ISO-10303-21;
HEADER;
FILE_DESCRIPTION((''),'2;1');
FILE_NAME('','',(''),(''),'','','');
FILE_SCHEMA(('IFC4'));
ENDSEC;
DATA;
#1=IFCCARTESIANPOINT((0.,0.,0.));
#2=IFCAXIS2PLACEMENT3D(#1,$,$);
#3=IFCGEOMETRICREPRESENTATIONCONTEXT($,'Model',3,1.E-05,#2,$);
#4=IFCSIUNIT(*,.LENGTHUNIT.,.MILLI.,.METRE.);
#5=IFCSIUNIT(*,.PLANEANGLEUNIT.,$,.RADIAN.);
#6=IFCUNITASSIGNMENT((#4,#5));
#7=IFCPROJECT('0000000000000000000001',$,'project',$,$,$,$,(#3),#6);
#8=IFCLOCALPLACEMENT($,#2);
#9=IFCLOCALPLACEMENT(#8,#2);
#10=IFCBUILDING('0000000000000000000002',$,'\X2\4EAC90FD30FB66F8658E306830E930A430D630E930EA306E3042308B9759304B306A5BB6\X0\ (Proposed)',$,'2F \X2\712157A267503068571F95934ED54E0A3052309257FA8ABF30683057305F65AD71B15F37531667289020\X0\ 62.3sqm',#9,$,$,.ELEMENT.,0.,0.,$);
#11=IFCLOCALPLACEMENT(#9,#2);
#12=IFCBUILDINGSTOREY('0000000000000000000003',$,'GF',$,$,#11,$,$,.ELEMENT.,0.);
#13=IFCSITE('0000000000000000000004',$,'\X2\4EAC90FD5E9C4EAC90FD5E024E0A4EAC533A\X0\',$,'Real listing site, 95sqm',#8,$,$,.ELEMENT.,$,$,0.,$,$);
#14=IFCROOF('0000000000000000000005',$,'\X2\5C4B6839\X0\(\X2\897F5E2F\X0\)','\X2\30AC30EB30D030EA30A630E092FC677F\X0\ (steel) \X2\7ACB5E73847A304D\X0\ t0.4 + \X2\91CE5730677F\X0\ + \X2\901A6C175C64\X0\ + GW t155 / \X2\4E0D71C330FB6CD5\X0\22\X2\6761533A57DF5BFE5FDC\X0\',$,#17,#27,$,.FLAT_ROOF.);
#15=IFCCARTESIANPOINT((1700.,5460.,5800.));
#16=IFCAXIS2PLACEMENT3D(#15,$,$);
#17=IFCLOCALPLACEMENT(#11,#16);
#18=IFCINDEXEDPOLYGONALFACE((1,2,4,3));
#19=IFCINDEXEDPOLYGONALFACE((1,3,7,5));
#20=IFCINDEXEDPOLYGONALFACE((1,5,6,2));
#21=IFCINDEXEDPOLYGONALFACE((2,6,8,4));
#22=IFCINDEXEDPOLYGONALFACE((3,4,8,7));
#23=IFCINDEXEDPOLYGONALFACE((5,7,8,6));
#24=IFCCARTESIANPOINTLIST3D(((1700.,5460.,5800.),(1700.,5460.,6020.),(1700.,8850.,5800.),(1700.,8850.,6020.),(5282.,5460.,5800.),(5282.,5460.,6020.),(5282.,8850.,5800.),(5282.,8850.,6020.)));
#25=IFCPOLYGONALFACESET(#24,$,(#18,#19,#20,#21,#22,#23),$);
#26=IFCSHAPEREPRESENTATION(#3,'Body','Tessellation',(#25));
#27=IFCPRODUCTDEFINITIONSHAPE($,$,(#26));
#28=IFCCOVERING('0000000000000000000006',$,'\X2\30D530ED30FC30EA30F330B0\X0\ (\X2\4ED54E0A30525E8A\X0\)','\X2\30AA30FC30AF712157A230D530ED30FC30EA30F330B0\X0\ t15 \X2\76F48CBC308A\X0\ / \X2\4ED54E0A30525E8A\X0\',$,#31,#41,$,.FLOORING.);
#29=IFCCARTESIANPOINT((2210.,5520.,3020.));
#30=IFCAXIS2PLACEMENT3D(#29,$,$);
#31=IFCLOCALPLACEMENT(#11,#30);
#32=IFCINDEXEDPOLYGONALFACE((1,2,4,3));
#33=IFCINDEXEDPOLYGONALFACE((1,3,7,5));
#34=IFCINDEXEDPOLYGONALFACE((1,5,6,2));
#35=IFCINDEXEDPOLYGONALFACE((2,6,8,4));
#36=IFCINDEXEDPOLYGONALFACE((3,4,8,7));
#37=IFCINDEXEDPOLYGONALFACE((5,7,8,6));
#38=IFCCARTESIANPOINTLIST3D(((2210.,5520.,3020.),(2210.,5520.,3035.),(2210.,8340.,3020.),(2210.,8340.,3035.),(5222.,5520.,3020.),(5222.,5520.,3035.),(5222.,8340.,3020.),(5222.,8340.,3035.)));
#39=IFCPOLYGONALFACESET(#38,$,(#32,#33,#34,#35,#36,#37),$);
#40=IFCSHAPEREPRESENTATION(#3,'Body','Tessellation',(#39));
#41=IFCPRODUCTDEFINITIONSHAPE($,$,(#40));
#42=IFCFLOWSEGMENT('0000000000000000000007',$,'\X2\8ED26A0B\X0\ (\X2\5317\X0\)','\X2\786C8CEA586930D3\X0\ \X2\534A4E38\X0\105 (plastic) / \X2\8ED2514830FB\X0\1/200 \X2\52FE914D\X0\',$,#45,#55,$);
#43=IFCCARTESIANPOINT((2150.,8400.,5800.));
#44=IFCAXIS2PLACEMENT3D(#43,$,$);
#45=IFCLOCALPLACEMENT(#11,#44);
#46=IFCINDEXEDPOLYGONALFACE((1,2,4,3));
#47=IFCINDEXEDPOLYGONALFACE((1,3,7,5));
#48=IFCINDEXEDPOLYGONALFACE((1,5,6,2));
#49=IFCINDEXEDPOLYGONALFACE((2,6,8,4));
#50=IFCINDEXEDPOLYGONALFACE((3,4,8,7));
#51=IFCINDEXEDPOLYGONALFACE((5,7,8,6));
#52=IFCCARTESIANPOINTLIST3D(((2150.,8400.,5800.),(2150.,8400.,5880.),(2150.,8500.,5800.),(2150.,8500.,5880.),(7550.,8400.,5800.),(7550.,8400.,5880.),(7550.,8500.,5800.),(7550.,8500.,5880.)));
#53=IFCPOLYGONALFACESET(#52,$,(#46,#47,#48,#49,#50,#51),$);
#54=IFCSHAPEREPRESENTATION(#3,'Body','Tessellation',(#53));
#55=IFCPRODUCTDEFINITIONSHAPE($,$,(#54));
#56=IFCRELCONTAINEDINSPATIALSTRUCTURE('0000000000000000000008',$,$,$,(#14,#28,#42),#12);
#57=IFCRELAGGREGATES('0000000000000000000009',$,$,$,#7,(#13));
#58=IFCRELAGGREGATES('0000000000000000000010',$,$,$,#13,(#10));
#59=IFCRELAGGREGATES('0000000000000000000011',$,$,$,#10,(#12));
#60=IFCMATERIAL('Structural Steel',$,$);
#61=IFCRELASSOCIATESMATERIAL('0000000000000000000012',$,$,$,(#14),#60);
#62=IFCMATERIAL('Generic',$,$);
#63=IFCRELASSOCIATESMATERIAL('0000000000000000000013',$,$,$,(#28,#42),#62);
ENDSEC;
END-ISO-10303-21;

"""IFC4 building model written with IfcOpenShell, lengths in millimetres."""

from ifc_helpers import new_model, si_unit, frame, frame_2d, origin, place, context, project, spatial, rectangle, extrude, material, element, save


model = new_model("IFC4")

# Units and contexts
model_context = context("Model", 3, precision=1e-05, world=origin())
ifc_project = project(units=[si_unit("LENGTHUNIT", "METRE", prefix="MILLI"), si_unit("PLANEANGLEUNIT", "RADIAN")], contexts=[model_context])

# Site, building, storey
site_placement = place(None, origin())
site = spatial("IfcSite", under=ifc_project, at=site_placement, Name="京都府京都市上京区", ObjectType="Real listing site, 95sqm", CompositionType="ELEMENT", RefElevation=0.0)
building_placement = place(site_placement, origin())
building = spatial("IfcBuilding", under=site, at=building_placement, Name="京都・書斎とライブラリのある静かな家 (Proposed)", ObjectType="2F 無垢材と土間仕上げを基調とした断熱強化木造 62.3sqm", CompositionType="ELEMENT", ElevationOfRefHeight=0.0, ElevationOfTerrain=0.0)
storey_placement = place(building_placement, origin())
storey = spatial("IfcBuildingStorey", under=building, at=storey_placement, Name="GF", CompositionType="ELEMENT", Elevation=0.0)

# Roof
ifc_material_1 = material(Name="Structural Steel")
for number, where, name in (
    (1, (1700.0, 5460.0, 5800.0), "屋根(西帯)"),
):
    element("IfcRoof", number, at=place(storey_placement, frame(where)), inside=storey, material=ifc_material_1, Name=name, Description="ガルバリウム鋼板 (steel) 立平葺き t0.4 + 野地板 + 通気層 + GW t155 / 不燃・法22条区域対応", PredefinedType="FLAT_ROOF", context=model_context, shape_type="SweptSolid", body=[
        extrude(rectangle(XDim=3582.0, YDim=3390.0, at=frame_2d((1791.0, 1695.0))), frame((1700.0, 5460.0, 5800.0)), (0.0, 0.0, 1.0), 220.0),
    ])

# Covering
ifc_material_2 = material(Name="Generic")
covering_placement = place(storey_placement, frame((2210.0, 5520.0, 3020.0)))
element("IfcCovering", 2, at=covering_placement, inside=storey, material=ifc_material_2, Name="フローリング (仕上げ床)", Description="オーク無垢フローリング t15 直貼り / 仕上げ床", PredefinedType="FLOORING", context=model_context, shape_type="SweptSolid", body=[
    extrude(rectangle(XDim=3012.0, YDim=2820.0, at=frame_2d((1506.0, 1410.0))), frame((2210.0, 5520.0, 3020.0)), (0.0, 0.0, 1.0), 15.0),
])

# Flow segment
flow_segment_placement = place(storey_placement, frame((2150.0, 8400.0, 5800.0)))
element("IfcFlowSegment", 3, at=flow_segment_placement, inside=storey, material=ifc_material_2, Name="軒樋 (北)", Description="硬質塩ビ 半丸105 (plastic) / 軒先・1/200 勾配", context=model_context, shape_type="SweptSolid", body=[
    extrude(rectangle(XDim=5400.0, YDim=100.0, at=frame_2d((2700.0, 50.0))), frame((2150.0, 8400.0, 5800.0)), (0.0, 0.0, 1.0), 80.0),
])

save(model, "model.ifc")
